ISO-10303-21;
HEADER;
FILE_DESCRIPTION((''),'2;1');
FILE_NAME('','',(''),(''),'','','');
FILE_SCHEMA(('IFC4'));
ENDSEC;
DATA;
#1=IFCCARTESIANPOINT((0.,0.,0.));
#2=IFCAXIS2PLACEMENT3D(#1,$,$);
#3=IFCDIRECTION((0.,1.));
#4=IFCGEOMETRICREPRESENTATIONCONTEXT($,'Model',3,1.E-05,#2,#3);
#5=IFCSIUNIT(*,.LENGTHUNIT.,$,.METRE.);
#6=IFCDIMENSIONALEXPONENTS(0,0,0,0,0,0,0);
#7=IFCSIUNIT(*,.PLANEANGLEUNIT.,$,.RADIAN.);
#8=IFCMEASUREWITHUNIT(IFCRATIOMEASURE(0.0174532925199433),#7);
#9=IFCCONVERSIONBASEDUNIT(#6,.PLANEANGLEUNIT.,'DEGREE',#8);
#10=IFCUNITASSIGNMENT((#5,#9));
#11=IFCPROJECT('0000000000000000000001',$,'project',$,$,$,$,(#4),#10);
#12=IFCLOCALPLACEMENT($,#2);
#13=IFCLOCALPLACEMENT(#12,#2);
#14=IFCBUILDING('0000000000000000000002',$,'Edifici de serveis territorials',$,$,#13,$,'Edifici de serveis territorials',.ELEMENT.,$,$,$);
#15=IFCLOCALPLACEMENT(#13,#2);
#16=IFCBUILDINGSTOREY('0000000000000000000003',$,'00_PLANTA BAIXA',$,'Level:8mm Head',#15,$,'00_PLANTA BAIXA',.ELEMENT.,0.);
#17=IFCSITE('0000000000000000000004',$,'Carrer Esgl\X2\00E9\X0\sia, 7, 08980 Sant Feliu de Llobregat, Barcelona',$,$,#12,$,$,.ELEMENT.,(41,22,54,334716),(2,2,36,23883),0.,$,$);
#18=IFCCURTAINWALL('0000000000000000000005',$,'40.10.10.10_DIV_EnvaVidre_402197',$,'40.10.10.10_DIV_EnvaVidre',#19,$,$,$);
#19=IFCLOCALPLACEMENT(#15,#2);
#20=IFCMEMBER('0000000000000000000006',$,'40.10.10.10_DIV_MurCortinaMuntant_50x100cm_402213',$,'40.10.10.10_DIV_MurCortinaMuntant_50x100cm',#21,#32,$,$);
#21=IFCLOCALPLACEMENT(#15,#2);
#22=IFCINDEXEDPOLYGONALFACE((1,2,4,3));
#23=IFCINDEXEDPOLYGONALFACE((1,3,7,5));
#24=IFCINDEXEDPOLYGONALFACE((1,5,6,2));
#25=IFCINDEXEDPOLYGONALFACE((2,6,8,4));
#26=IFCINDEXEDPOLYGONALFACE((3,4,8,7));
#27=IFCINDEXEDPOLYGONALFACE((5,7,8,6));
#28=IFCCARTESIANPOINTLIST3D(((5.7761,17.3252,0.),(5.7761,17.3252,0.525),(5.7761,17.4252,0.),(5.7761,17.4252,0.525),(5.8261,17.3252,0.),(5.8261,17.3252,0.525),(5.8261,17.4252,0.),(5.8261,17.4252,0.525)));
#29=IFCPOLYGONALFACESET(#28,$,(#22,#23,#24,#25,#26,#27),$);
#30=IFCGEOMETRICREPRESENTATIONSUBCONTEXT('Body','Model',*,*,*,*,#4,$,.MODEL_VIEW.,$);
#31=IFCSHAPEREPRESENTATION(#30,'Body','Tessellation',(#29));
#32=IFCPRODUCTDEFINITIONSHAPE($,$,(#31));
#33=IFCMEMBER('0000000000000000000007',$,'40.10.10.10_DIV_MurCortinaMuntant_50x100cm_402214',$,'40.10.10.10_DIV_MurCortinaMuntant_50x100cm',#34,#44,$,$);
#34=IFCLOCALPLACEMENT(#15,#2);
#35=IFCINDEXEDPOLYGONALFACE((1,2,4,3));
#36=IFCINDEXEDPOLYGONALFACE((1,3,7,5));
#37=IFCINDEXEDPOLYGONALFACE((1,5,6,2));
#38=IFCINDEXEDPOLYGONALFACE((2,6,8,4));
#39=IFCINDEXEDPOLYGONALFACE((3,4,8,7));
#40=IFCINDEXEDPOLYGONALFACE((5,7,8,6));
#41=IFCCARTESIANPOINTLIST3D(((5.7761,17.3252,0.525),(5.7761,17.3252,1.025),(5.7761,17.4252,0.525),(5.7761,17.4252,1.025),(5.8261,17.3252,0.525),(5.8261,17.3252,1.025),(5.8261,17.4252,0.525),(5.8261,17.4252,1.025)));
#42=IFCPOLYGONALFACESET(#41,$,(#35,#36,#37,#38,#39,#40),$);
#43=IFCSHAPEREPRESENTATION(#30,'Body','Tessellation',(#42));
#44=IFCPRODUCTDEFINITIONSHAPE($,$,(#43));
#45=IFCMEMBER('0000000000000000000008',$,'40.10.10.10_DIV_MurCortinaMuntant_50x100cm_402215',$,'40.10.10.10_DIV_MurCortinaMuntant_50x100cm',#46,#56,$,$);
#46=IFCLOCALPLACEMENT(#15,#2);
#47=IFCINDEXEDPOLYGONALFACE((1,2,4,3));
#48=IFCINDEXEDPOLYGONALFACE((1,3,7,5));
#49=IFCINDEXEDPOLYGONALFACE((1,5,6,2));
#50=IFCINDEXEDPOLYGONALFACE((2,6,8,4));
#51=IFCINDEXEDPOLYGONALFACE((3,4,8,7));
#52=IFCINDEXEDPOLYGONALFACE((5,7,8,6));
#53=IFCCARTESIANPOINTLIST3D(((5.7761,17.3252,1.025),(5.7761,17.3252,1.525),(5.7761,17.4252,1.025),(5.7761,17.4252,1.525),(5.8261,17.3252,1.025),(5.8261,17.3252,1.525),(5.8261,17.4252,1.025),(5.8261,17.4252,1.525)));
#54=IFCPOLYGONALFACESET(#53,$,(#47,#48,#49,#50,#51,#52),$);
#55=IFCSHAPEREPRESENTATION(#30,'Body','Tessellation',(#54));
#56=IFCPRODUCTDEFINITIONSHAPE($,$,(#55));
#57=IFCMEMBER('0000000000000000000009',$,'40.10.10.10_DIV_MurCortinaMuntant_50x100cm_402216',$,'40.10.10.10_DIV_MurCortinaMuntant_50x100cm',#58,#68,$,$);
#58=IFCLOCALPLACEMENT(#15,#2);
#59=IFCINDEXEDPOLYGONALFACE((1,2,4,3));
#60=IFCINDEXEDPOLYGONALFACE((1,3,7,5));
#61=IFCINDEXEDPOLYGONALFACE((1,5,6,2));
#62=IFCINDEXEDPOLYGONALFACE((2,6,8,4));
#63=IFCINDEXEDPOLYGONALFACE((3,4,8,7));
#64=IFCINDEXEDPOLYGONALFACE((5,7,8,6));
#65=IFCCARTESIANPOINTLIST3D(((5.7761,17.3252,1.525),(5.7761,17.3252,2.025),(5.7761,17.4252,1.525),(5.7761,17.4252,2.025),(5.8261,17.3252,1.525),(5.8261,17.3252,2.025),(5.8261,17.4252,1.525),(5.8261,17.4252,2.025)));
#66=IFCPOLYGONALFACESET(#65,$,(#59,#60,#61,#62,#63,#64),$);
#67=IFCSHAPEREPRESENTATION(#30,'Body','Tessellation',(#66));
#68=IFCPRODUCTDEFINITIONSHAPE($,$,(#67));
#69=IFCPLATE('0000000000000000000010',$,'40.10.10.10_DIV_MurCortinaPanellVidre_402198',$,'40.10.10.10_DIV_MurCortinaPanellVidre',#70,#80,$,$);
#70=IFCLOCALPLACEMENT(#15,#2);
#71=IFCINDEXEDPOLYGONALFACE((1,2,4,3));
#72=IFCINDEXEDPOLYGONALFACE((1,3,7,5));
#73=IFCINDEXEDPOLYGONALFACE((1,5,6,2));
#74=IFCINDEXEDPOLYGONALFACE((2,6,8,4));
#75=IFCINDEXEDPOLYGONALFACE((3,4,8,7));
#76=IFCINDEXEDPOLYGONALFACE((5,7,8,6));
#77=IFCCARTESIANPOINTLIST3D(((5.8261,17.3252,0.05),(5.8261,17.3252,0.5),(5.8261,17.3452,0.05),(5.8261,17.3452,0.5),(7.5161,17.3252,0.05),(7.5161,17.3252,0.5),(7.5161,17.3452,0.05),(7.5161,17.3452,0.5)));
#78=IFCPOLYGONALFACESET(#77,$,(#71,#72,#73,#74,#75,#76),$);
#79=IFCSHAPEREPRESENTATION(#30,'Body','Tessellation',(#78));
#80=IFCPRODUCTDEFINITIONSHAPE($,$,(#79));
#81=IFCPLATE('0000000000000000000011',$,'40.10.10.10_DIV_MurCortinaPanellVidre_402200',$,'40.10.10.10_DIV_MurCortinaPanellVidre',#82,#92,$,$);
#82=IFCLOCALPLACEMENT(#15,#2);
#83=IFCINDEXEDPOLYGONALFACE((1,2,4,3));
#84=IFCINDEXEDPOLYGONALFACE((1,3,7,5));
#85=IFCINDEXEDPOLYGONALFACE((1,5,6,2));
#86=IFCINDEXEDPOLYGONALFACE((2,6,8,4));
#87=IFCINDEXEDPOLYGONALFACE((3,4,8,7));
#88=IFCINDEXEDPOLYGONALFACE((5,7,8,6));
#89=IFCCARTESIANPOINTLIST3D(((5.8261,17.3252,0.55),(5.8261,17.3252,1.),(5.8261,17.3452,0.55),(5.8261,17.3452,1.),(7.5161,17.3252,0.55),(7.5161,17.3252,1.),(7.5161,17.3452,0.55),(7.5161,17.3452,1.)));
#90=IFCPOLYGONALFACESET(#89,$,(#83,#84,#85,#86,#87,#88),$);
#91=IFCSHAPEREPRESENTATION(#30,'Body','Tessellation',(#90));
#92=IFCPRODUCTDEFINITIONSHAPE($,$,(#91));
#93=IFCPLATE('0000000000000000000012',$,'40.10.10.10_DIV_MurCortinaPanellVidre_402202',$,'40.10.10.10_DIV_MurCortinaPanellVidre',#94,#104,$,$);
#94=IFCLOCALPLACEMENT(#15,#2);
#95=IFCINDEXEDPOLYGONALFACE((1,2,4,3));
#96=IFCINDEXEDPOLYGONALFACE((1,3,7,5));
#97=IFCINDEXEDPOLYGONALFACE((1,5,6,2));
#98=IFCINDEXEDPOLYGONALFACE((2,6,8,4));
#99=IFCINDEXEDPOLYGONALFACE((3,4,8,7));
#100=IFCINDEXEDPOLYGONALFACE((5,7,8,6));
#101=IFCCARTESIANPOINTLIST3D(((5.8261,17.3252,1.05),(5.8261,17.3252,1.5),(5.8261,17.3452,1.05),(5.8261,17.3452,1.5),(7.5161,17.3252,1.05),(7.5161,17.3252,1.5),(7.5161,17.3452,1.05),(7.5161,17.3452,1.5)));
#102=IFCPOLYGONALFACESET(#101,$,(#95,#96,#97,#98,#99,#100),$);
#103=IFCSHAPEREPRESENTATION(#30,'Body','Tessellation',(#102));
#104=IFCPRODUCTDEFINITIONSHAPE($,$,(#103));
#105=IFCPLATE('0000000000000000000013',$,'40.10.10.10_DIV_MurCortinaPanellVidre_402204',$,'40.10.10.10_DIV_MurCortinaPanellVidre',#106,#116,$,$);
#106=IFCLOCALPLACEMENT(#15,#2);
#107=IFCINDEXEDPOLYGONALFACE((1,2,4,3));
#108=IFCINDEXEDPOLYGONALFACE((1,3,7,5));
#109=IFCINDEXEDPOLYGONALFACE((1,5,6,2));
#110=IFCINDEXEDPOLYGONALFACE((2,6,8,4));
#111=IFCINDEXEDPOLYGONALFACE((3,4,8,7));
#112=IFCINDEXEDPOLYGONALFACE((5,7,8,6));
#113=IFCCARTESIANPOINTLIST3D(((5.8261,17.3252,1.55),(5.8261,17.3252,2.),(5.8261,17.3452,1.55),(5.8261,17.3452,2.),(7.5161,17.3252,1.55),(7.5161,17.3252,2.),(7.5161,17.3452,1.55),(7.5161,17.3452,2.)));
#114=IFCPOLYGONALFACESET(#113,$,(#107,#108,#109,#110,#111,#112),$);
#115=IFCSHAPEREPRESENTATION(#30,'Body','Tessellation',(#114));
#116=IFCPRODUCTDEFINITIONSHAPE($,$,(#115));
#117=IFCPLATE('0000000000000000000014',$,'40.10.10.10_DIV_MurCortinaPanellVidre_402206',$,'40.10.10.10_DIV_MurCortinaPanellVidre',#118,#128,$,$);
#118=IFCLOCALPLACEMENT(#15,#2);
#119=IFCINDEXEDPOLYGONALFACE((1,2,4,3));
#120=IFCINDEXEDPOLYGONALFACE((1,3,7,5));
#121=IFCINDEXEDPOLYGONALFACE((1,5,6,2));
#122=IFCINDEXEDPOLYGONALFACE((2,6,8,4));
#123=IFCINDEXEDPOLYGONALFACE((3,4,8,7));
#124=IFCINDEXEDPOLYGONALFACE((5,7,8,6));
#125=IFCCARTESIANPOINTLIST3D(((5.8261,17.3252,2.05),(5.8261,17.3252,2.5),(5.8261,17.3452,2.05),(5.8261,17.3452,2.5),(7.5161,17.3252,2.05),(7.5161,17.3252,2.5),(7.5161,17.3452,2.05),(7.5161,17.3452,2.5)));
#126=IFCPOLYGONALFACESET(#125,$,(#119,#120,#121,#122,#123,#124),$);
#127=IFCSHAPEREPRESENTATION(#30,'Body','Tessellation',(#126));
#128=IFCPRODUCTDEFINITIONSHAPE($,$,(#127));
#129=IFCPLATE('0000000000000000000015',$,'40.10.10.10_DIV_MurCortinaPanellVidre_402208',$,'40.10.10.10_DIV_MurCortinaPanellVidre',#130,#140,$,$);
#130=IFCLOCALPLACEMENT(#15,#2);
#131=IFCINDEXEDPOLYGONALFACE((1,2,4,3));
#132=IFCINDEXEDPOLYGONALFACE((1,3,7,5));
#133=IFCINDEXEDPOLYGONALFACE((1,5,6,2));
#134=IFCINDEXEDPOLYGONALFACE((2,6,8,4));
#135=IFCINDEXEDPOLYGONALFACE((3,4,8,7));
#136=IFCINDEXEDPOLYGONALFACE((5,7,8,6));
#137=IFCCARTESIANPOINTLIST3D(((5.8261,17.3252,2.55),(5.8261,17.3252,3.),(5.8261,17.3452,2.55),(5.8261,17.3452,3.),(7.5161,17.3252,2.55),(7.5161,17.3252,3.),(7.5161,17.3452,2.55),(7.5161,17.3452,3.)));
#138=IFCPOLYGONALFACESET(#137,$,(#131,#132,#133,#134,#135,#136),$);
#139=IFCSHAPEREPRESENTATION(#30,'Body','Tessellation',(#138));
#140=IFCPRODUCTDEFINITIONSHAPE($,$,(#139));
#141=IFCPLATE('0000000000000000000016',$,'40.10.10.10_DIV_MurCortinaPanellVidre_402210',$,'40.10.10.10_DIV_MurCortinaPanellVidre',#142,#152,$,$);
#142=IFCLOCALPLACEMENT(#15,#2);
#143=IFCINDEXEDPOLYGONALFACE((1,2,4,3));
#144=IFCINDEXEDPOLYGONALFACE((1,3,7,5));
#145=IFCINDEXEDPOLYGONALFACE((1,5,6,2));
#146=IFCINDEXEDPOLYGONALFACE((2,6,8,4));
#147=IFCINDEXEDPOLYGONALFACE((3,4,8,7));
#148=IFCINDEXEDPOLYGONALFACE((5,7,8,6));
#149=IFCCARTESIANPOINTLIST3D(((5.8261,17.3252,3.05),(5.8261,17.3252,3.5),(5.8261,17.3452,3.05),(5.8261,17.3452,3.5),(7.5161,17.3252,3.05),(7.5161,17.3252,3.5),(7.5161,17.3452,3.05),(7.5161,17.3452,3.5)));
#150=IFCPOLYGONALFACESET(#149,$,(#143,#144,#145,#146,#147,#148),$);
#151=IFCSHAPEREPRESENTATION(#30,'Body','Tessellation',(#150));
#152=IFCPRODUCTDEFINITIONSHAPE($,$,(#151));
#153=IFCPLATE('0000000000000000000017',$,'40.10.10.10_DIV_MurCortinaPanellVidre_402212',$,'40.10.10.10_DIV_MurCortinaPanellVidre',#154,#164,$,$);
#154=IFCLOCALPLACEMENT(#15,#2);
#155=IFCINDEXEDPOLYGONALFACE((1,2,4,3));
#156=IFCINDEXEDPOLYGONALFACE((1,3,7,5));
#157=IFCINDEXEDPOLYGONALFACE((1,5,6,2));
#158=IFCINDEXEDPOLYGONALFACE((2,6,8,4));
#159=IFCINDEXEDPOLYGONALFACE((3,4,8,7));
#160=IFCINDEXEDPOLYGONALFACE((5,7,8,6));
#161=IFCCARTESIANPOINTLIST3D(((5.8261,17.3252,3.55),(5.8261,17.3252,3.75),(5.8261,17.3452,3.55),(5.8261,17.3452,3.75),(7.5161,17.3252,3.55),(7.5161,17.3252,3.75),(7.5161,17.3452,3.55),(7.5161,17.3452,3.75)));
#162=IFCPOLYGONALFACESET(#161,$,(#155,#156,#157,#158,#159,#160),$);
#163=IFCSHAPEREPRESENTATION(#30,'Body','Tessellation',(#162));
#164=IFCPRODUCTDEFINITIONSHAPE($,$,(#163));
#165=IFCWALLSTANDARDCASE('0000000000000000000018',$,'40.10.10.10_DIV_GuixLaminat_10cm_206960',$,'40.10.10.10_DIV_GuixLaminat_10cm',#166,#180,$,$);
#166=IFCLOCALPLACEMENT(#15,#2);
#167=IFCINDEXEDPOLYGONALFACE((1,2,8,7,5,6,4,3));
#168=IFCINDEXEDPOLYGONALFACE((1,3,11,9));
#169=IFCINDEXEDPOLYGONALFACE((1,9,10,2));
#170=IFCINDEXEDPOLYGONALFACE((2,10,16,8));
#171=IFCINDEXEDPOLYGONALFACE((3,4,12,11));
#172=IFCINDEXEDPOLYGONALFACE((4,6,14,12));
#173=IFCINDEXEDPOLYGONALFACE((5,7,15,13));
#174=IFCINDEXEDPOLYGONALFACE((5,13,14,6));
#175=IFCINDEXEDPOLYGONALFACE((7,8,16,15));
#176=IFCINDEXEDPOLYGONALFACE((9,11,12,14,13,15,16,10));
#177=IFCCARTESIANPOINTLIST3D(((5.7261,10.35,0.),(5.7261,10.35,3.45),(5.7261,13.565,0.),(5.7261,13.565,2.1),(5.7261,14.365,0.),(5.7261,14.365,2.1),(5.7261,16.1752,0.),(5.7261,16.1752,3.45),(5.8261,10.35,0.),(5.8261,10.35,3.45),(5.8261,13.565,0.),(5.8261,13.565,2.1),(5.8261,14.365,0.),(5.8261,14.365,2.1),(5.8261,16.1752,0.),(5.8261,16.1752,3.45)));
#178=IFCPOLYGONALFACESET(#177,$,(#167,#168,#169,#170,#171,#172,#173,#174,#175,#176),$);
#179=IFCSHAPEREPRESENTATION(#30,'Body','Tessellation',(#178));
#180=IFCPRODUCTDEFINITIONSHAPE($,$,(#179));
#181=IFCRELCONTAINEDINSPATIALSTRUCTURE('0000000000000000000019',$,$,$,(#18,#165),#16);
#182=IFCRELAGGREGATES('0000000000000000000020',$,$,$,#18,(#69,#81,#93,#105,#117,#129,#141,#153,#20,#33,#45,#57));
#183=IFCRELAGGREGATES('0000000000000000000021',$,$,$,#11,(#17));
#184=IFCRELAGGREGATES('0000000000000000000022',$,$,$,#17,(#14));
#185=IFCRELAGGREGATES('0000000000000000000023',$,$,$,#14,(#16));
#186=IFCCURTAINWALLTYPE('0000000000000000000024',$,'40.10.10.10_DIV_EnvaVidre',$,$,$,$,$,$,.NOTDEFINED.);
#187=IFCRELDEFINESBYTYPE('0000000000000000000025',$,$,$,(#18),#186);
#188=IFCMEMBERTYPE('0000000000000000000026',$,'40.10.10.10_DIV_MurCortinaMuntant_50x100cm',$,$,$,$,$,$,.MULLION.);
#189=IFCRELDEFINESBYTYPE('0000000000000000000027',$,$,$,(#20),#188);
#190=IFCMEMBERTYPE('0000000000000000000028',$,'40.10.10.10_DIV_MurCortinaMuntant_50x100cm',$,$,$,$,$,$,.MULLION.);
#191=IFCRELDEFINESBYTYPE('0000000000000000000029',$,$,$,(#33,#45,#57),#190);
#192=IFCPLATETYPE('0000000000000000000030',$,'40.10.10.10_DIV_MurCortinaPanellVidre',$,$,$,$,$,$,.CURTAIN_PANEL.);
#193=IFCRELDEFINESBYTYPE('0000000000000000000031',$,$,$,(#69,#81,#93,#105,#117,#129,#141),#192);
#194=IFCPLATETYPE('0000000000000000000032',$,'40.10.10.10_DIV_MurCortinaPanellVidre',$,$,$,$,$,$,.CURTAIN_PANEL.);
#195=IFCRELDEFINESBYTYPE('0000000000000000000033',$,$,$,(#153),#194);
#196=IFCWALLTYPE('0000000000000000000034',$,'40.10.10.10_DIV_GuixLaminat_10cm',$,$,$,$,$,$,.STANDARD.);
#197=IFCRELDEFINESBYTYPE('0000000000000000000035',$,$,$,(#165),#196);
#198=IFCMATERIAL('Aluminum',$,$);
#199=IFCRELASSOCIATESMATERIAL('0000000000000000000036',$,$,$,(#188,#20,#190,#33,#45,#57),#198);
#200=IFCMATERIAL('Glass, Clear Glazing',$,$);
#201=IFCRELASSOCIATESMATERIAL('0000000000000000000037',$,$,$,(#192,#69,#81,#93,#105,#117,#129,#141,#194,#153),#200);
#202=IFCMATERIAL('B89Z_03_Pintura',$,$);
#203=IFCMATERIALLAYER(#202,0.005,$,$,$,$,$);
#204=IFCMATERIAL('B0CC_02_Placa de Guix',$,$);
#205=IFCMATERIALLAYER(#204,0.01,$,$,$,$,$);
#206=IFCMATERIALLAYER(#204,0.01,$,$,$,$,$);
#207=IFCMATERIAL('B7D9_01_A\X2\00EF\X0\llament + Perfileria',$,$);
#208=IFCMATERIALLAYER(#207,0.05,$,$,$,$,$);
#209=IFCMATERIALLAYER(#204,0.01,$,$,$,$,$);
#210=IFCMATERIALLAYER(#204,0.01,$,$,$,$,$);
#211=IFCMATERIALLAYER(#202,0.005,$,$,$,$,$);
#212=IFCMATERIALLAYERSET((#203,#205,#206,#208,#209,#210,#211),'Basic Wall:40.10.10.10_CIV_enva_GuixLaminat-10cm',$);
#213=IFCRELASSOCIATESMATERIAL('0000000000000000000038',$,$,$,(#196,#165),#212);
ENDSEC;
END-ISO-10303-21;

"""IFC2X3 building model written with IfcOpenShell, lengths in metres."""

from ifc_helpers import new_model, entity, si_unit, converted_unit, direction, frame, frame_2d, origin, origin_2d_with_axis, place, context, subcontext, project, spatial, polyline, rectangle, extrude, clip, bounded_halfspace, source, transform, mapped, material, layer, layer_set, layer_usage, type_object, type_shapes, element, aggregate, save


model = new_model("IFC2X3")

# Units and contexts
model_context = context("Model", 3, precision=1e-05, world=origin(), true_north=direction((0.0, 1.0)))
body_context = subcontext(model_context, "Body", "Model", "MODEL_VIEW")
ifc_project = project(units=[si_unit("LENGTHUNIT", "METRE"), converted_unit("PLANEANGLEUNIT", "DEGREE", entity("IfcRatioMeasure", 0.0174532925199433), si_unit("PLANEANGLEUNIT", "RADIAN"), dimensions=[0, 0, 0, 0, 0, 0, 0])], contexts=[model_context])

# Site, building, storey
site_placement = place(None, origin())
site = spatial("IfcSite", under=ifc_project, at=site_placement, Name="Carrer Església, 7, 08980 Sant Feliu de Llobregat, Barcelona", CompositionType="ELEMENT", RefLatitude=(41, 22, 54, 334716), RefLongitude=(2, 2, 36, 23883), RefElevation=0.0)
building_placement = place(site_placement, origin())
building = spatial("IfcBuilding", under=site, at=building_placement, Name="Edifici de serveis territorials", LongName="Edifici de serveis territorials", CompositionType="ELEMENT")
storey_placement = place(building_placement, origin())
storey = spatial("IfcBuildingStorey", under=building, at=storey_placement, Name="00_PLANTA BAIXA", ObjectType="Level:8mm Head", LongName="00_PLANTA BAIXA", CompositionType="ELEMENT", Elevation=0.0)

# Curtain wall, members, plates
curtain_wall_type = type_object("IfcCurtainWallType", Name="40.10.10.10_DIV_EnvaVidre", PredefinedType="NOTDEFINED")
curtain_wall_placement = place(storey_placement, origin())
curtain_wall = element("IfcCurtainWall", 1, at=curtain_wall_placement, inside=storey, type_object=curtain_wall_type, Name="40.10.10.10_DIV_EnvaVidre_402197", ObjectType="40.10.10.10_DIV_EnvaVidre")
ifc_material_1 = material(Name="Aluminum")
member_type_1 = type_object("IfcMemberType", Name="40.10.10.10_DIV_MurCortinaMuntant_50x100cm", PredefinedType="MULLION", material=ifc_material_1)
shared_shape_1 = source(origin(), body_context, "Body", "SweptSolid", [
    extrude(rectangle(XDim=0.1, YDim=0.05, at=origin_2d_with_axis()), frame((-0.025, 0.0, -0.525), z_axis=(0.0, 0.0, 1.0), x_axis=(0.0, -1.0, 0.0)), (0.0, 0.0, 1.0), 0.525),
])
type_shapes(member_type_1, [shared_shape_1])
member_1_placement = place(storey_placement, frame((5.7761, 17.3752, 0.0), z_axis=(0.0, 0.0, -1.0), x_axis=(-1.0, 0.0, 0.0)))
member_1 = element("IfcMember", 2, at=member_1_placement, type_object=member_type_1, material=ifc_material_1, Name="40.10.10.10_DIV_MurCortinaMuntant_50x100cm_402213", ObjectType="40.10.10.10_DIV_MurCortinaMuntant_50x100cm", context=body_context, shape_type="MappedRepresentation", body=[
    mapped(shared_shape_1, transform((0.0, 0.0, 0.0), scale=1.0)),
])
member_type_2 = type_object("IfcMemberType", Name="40.10.10.10_DIV_MurCortinaMuntant_50x100cm", PredefinedType="MULLION", material=ifc_material_1)
shared_shape_2 = source(origin(), body_context, "Body", "SweptSolid", [
    extrude(rectangle(XDim=0.1, YDim=0.05, at=origin_2d_with_axis()), frame((-0.025, 0.0, -0.5), z_axis=(0.0, 0.0, 1.0), x_axis=(0.0, -1.0, 0.0)), (0.0, 0.0, 1.0), 0.5),
])
type_shapes(member_type_2, [shared_shape_2])
member_2_placement = place(storey_placement, frame((5.7761, 17.3752, 0.525), z_axis=(0.0, 0.0, -1.0), x_axis=(-1.0, 0.0, 0.0)))
member_2 = element("IfcMember", 3, at=member_2_placement, type_object=member_type_2, material=ifc_material_1, Name="40.10.10.10_DIV_MurCortinaMuntant_50x100cm_402214", ObjectType="40.10.10.10_DIV_MurCortinaMuntant_50x100cm", context=body_context, shape_type="MappedRepresentation", body=[
    mapped(shared_shape_2, transform((0.0, 0.0, 0.0), scale=1.0)),
])
member_3_placement = place(storey_placement, frame((5.7761, 17.3752, 1.025), z_axis=(0.0, 0.0, -1.0), x_axis=(-1.0, 0.0, 0.0)))
member_3 = element("IfcMember", 4, at=member_3_placement, type_object=member_type_2, material=ifc_material_1, Name="40.10.10.10_DIV_MurCortinaMuntant_50x100cm_402215", ObjectType="40.10.10.10_DIV_MurCortinaMuntant_50x100cm", context=body_context, shape_type="MappedRepresentation", body=[
    mapped(shared_shape_2, transform((0.0, 0.0, 0.0), scale=1.0)),
])
member_4_placement = place(storey_placement, frame((5.7761, 17.3752, 1.525), z_axis=(0.0, 0.0, -1.0), x_axis=(-1.0, 0.0, 0.0)))
member_4 = element("IfcMember", 5, at=member_4_placement, type_object=member_type_2, material=ifc_material_1, Name="40.10.10.10_DIV_MurCortinaMuntant_50x100cm_402216", ObjectType="40.10.10.10_DIV_MurCortinaMuntant_50x100cm", context=body_context, shape_type="MappedRepresentation", body=[
    mapped(shared_shape_2, transform((0.0, 0.0, 0.0), scale=1.0)),
])
ifc_material_2 = material(Name="Glass, Clear Glazing")
plate_type_1 = type_object("IfcPlateType", Name="40.10.10.10_DIV_MurCortinaPanellVidre", PredefinedType="CURTAIN_PANEL", material=ifc_material_2)
shared_shape_3 = source(origin(), body_context, "Body", "SweptSolid", [
    extrude(rectangle(XDim=0.02, YDim=1.69, at=frame_2d((0.0, 0.0), x_axis=(1.0, 0.0))), frame((0.845, 0.01, 0.0), z_axis=(0.0, 0.0, 1.0), x_axis=(0.0, 1.0, 0.0)), (0.0, 0.0, 1.0), 0.45),
])
type_shapes(plate_type_1, [shared_shape_3])
plate_1_placement = place(curtain_wall_placement, frame((7.5161, 17.3452, 0.05), z_axis=(0.0, 0.0, 1.0), x_axis=(-1.0, 0.0, 0.0)))
plate_1 = element("IfcPlate", 6, at=plate_1_placement, type_object=plate_type_1, material=ifc_material_2, Name="40.10.10.10_DIV_MurCortinaPanellVidre_402198", ObjectType="40.10.10.10_DIV_MurCortinaPanellVidre", context=body_context, shape_type="MappedRepresentation", body=[
    mapped(shared_shape_3, transform((0.0, 0.0, 0.0), scale=1.0)),
])
plate_2_placement = place(curtain_wall_placement, frame((7.5161, 17.3452, 0.55), z_axis=(0.0, 0.0, 1.0), x_axis=(-1.0, 0.0, 0.0)))
plate_2 = element("IfcPlate", 7, at=plate_2_placement, type_object=plate_type_1, material=ifc_material_2, Name="40.10.10.10_DIV_MurCortinaPanellVidre_402200", ObjectType="40.10.10.10_DIV_MurCortinaPanellVidre", context=body_context, shape_type="MappedRepresentation", body=[
    mapped(shared_shape_3, transform((0.0, 0.0, 0.0), scale=1.0)),
])
plate_3_placement = place(curtain_wall_placement, frame((7.5161, 17.3452, 1.05), z_axis=(0.0, 0.0, 1.0), x_axis=(-1.0, 0.0, 0.0)))
plate_3 = element("IfcPlate", 8, at=plate_3_placement, type_object=plate_type_1, material=ifc_material_2, Name="40.10.10.10_DIV_MurCortinaPanellVidre_402202", ObjectType="40.10.10.10_DIV_MurCortinaPanellVidre", context=body_context, shape_type="MappedRepresentation", body=[
    mapped(shared_shape_3, transform((0.0, 0.0, 0.0), scale=1.0)),
])
plate_4_placement = place(curtain_wall_placement, frame((7.5161, 17.3452, 1.55), z_axis=(0.0, 0.0, 1.0), x_axis=(-1.0, 0.0, 0.0)))
plate_4 = element("IfcPlate", 9, at=plate_4_placement, type_object=plate_type_1, material=ifc_material_2, Name="40.10.10.10_DIV_MurCortinaPanellVidre_402204", ObjectType="40.10.10.10_DIV_MurCortinaPanellVidre", context=body_context, shape_type="MappedRepresentation", body=[
    mapped(shared_shape_3, transform((0.0, 0.0, 0.0), scale=1.0)),
])
plate_5_placement = place(curtain_wall_placement, frame((7.5161, 17.3452, 2.05), z_axis=(0.0, 0.0, 1.0), x_axis=(-1.0, 0.0, 0.0)))
plate_5 = element("IfcPlate", 10, at=plate_5_placement, type_object=plate_type_1, material=ifc_material_2, Name="40.10.10.10_DIV_MurCortinaPanellVidre_402206", ObjectType="40.10.10.10_DIV_MurCortinaPanellVidre", context=body_context, shape_type="MappedRepresentation", body=[
    mapped(shared_shape_3, transform((0.0, 0.0, 0.0), scale=1.0)),
])
plate_6_placement = place(curtain_wall_placement, frame((7.5161, 17.3452, 2.55), z_axis=(0.0, 0.0, 1.0), x_axis=(-1.0, 0.0, 0.0)))
plate_6 = element("IfcPlate", 11, at=plate_6_placement, type_object=plate_type_1, material=ifc_material_2, Name="40.10.10.10_DIV_MurCortinaPanellVidre_402208", ObjectType="40.10.10.10_DIV_MurCortinaPanellVidre", context=body_context, shape_type="MappedRepresentation", body=[
    mapped(shared_shape_3, transform((0.0, 0.0, 0.0), scale=1.0)),
])
plate_7_placement = place(curtain_wall_placement, frame((7.5161, 17.3452, 3.05), z_axis=(0.0, 0.0, 1.0), x_axis=(-1.0, 0.0, 0.0)))
plate_7 = element("IfcPlate", 12, at=plate_7_placement, type_object=plate_type_1, material=ifc_material_2, Name="40.10.10.10_DIV_MurCortinaPanellVidre_402210", ObjectType="40.10.10.10_DIV_MurCortinaPanellVidre", context=body_context, shape_type="MappedRepresentation", body=[
    mapped(shared_shape_3, transform((0.0, 0.0, 0.0), scale=1.0)),
])
plate_type_2 = type_object("IfcPlateType", Name="40.10.10.10_DIV_MurCortinaPanellVidre", PredefinedType="CURTAIN_PANEL", material=ifc_material_2)
shared_shape_4 = source(origin(), body_context, "Body", "SweptSolid", [
    extrude(rectangle(XDim=0.02, YDim=1.69, at=frame_2d((0.0, 0.0), x_axis=(1.0, 0.0))), frame((0.845, 0.01, 0.0), z_axis=(0.0, 0.0, 1.0), x_axis=(0.0, 1.0, 0.0)), (0.0, 0.0, 1.0), 0.2),
])
type_shapes(plate_type_2, [shared_shape_4])
plate_8_placement = place(curtain_wall_placement, frame((7.5161, 17.3452, 3.55), z_axis=(0.0, 0.0, 1.0), x_axis=(-1.0, 0.0, 0.0)))
plate_8 = element("IfcPlate", 13, at=plate_8_placement, type_object=plate_type_2, material=ifc_material_2, Name="40.10.10.10_DIV_MurCortinaPanellVidre_402212", ObjectType="40.10.10.10_DIV_MurCortinaPanellVidre", context=body_context, shape_type="MappedRepresentation", body=[
    mapped(shared_shape_4, transform((0.0, 0.0, 0.0), scale=1.0)),
])
aggregate(curtain_wall, [plate_1, plate_2, plate_3, plate_4, plate_5, plate_6, plate_7, plate_8, member_1, member_2, member_3, member_4])

# Wall, openings
ifc_material_3 = material(Name="B89Z_03_Pintura")
ifc_layer_1 = layer(ifc_material_3, 0.005)
ifc_material_4 = material(Name="B0CC_02_Placa de Guix")
ifc_layer_2 = layer(ifc_material_4, 0.01)
ifc_layer_3 = layer(ifc_material_4, 0.01)
ifc_material_5 = material(Name="B7D9_01_Aïllament + Perfileria")
ifc_layer_4 = layer(ifc_material_5, 0.05)
ifc_layer_5 = layer(ifc_material_4, 0.01)
ifc_layer_6 = layer(ifc_material_4, 0.01)
ifc_layer_7 = layer(ifc_material_3, 0.005)
ifc_layer_set_1 = layer_set([ifc_layer_1, ifc_layer_2, ifc_layer_3, ifc_layer_4, ifc_layer_5, ifc_layer_6, ifc_layer_7], Name="Basic Wall:40.10.10.10_CIV_enva_GuixLaminat-10cm")
ifc_layer_usage_1 = layer_usage(ifc_layer_set_1, "AXIS2", "NEGATIVE", 0.05)
wall_type_1 = type_object("IfcWallType", Name="40.10.10.10_DIV_GuixLaminat_10cm", PredefinedType="STANDARD", material=ifc_layer_set_1)
wall_1_placement = place(storey_placement, frame((5.7761, 16.1752, 0.0), z_axis=(0.0, 0.0, 1.0), x_axis=(0.0, -1.0, 0.0)))
wall_1 = element("IfcWallStandardCase", 14, at=wall_1_placement, inside=storey, type_object=wall_type_1, material=ifc_layer_usage_1, Name="40.10.10.10_DIV_GuixLaminat_10cm_206960", ObjectType="40.10.10.10_DIV_GuixLaminat_10cm", context=body_context, shape_type="Clipping", body=[
    clip(extrude(rectangle(XDim=5.8252, YDim=0.1, at=frame_2d((2.9126, 0.0), x_axis=(-1.0, 0.0))), origin(), (0.0, 0.0, 1.0), 3.45), bounded_halfspace(frame((0.0, -0.05, 3.45), z_axis=(0.0, 0.0, -1.0), x_axis=(0.999675, 0.025497, 0.0)), True, frame((0.0, -0.05, 3.45)), polyline([(0.0, 0.0), (5.8252, 0.0), (5.8252, 0.1), (0.0, 0.1), (0.0, 0.0)]))),
])
opening_1_placement = place(wall_1_placement, frame((1.4902, -0.05, 0.0)))
element("IfcOpeningElement", 15, at=opening_1_placement, cuts=wall_1, ObjectType="Opening", context=body_context, shape_type="SweptSolid", body=[
    extrude(rectangle(XDim=2.1, YDim=0.8, at=frame_2d((1.05, 0.4), x_axis=(1.0, 0.0))), frame((0.0, 0.0, 0.0), z_axis=(0.0, -1.0, 0.0), x_axis=(0.0, 0.0, 1.0)), (0.0, 0.0, 1.0), 0.1),
])
opening_2_placement = place(wall_1_placement, frame((2.6102, 0.05, 0.0)))
element("IfcOpeningElement", 16, at=opening_2_placement, cuts=wall_1, ObjectType="Opening", context=body_context, shape_type="SweptSolid", body=[
    extrude(rectangle(XDim=2.1, YDim=0.8, at=frame_2d((1.05, 0.4), x_axis=(1.0, 0.0))), frame((0.0, 0.0, 0.0), z_axis=(0.0, -1.0, 0.0), x_axis=(0.0, 0.0, 1.0)), (0.0, 0.0, 1.0), 0.1),
])

save(model, "model.ifc")
